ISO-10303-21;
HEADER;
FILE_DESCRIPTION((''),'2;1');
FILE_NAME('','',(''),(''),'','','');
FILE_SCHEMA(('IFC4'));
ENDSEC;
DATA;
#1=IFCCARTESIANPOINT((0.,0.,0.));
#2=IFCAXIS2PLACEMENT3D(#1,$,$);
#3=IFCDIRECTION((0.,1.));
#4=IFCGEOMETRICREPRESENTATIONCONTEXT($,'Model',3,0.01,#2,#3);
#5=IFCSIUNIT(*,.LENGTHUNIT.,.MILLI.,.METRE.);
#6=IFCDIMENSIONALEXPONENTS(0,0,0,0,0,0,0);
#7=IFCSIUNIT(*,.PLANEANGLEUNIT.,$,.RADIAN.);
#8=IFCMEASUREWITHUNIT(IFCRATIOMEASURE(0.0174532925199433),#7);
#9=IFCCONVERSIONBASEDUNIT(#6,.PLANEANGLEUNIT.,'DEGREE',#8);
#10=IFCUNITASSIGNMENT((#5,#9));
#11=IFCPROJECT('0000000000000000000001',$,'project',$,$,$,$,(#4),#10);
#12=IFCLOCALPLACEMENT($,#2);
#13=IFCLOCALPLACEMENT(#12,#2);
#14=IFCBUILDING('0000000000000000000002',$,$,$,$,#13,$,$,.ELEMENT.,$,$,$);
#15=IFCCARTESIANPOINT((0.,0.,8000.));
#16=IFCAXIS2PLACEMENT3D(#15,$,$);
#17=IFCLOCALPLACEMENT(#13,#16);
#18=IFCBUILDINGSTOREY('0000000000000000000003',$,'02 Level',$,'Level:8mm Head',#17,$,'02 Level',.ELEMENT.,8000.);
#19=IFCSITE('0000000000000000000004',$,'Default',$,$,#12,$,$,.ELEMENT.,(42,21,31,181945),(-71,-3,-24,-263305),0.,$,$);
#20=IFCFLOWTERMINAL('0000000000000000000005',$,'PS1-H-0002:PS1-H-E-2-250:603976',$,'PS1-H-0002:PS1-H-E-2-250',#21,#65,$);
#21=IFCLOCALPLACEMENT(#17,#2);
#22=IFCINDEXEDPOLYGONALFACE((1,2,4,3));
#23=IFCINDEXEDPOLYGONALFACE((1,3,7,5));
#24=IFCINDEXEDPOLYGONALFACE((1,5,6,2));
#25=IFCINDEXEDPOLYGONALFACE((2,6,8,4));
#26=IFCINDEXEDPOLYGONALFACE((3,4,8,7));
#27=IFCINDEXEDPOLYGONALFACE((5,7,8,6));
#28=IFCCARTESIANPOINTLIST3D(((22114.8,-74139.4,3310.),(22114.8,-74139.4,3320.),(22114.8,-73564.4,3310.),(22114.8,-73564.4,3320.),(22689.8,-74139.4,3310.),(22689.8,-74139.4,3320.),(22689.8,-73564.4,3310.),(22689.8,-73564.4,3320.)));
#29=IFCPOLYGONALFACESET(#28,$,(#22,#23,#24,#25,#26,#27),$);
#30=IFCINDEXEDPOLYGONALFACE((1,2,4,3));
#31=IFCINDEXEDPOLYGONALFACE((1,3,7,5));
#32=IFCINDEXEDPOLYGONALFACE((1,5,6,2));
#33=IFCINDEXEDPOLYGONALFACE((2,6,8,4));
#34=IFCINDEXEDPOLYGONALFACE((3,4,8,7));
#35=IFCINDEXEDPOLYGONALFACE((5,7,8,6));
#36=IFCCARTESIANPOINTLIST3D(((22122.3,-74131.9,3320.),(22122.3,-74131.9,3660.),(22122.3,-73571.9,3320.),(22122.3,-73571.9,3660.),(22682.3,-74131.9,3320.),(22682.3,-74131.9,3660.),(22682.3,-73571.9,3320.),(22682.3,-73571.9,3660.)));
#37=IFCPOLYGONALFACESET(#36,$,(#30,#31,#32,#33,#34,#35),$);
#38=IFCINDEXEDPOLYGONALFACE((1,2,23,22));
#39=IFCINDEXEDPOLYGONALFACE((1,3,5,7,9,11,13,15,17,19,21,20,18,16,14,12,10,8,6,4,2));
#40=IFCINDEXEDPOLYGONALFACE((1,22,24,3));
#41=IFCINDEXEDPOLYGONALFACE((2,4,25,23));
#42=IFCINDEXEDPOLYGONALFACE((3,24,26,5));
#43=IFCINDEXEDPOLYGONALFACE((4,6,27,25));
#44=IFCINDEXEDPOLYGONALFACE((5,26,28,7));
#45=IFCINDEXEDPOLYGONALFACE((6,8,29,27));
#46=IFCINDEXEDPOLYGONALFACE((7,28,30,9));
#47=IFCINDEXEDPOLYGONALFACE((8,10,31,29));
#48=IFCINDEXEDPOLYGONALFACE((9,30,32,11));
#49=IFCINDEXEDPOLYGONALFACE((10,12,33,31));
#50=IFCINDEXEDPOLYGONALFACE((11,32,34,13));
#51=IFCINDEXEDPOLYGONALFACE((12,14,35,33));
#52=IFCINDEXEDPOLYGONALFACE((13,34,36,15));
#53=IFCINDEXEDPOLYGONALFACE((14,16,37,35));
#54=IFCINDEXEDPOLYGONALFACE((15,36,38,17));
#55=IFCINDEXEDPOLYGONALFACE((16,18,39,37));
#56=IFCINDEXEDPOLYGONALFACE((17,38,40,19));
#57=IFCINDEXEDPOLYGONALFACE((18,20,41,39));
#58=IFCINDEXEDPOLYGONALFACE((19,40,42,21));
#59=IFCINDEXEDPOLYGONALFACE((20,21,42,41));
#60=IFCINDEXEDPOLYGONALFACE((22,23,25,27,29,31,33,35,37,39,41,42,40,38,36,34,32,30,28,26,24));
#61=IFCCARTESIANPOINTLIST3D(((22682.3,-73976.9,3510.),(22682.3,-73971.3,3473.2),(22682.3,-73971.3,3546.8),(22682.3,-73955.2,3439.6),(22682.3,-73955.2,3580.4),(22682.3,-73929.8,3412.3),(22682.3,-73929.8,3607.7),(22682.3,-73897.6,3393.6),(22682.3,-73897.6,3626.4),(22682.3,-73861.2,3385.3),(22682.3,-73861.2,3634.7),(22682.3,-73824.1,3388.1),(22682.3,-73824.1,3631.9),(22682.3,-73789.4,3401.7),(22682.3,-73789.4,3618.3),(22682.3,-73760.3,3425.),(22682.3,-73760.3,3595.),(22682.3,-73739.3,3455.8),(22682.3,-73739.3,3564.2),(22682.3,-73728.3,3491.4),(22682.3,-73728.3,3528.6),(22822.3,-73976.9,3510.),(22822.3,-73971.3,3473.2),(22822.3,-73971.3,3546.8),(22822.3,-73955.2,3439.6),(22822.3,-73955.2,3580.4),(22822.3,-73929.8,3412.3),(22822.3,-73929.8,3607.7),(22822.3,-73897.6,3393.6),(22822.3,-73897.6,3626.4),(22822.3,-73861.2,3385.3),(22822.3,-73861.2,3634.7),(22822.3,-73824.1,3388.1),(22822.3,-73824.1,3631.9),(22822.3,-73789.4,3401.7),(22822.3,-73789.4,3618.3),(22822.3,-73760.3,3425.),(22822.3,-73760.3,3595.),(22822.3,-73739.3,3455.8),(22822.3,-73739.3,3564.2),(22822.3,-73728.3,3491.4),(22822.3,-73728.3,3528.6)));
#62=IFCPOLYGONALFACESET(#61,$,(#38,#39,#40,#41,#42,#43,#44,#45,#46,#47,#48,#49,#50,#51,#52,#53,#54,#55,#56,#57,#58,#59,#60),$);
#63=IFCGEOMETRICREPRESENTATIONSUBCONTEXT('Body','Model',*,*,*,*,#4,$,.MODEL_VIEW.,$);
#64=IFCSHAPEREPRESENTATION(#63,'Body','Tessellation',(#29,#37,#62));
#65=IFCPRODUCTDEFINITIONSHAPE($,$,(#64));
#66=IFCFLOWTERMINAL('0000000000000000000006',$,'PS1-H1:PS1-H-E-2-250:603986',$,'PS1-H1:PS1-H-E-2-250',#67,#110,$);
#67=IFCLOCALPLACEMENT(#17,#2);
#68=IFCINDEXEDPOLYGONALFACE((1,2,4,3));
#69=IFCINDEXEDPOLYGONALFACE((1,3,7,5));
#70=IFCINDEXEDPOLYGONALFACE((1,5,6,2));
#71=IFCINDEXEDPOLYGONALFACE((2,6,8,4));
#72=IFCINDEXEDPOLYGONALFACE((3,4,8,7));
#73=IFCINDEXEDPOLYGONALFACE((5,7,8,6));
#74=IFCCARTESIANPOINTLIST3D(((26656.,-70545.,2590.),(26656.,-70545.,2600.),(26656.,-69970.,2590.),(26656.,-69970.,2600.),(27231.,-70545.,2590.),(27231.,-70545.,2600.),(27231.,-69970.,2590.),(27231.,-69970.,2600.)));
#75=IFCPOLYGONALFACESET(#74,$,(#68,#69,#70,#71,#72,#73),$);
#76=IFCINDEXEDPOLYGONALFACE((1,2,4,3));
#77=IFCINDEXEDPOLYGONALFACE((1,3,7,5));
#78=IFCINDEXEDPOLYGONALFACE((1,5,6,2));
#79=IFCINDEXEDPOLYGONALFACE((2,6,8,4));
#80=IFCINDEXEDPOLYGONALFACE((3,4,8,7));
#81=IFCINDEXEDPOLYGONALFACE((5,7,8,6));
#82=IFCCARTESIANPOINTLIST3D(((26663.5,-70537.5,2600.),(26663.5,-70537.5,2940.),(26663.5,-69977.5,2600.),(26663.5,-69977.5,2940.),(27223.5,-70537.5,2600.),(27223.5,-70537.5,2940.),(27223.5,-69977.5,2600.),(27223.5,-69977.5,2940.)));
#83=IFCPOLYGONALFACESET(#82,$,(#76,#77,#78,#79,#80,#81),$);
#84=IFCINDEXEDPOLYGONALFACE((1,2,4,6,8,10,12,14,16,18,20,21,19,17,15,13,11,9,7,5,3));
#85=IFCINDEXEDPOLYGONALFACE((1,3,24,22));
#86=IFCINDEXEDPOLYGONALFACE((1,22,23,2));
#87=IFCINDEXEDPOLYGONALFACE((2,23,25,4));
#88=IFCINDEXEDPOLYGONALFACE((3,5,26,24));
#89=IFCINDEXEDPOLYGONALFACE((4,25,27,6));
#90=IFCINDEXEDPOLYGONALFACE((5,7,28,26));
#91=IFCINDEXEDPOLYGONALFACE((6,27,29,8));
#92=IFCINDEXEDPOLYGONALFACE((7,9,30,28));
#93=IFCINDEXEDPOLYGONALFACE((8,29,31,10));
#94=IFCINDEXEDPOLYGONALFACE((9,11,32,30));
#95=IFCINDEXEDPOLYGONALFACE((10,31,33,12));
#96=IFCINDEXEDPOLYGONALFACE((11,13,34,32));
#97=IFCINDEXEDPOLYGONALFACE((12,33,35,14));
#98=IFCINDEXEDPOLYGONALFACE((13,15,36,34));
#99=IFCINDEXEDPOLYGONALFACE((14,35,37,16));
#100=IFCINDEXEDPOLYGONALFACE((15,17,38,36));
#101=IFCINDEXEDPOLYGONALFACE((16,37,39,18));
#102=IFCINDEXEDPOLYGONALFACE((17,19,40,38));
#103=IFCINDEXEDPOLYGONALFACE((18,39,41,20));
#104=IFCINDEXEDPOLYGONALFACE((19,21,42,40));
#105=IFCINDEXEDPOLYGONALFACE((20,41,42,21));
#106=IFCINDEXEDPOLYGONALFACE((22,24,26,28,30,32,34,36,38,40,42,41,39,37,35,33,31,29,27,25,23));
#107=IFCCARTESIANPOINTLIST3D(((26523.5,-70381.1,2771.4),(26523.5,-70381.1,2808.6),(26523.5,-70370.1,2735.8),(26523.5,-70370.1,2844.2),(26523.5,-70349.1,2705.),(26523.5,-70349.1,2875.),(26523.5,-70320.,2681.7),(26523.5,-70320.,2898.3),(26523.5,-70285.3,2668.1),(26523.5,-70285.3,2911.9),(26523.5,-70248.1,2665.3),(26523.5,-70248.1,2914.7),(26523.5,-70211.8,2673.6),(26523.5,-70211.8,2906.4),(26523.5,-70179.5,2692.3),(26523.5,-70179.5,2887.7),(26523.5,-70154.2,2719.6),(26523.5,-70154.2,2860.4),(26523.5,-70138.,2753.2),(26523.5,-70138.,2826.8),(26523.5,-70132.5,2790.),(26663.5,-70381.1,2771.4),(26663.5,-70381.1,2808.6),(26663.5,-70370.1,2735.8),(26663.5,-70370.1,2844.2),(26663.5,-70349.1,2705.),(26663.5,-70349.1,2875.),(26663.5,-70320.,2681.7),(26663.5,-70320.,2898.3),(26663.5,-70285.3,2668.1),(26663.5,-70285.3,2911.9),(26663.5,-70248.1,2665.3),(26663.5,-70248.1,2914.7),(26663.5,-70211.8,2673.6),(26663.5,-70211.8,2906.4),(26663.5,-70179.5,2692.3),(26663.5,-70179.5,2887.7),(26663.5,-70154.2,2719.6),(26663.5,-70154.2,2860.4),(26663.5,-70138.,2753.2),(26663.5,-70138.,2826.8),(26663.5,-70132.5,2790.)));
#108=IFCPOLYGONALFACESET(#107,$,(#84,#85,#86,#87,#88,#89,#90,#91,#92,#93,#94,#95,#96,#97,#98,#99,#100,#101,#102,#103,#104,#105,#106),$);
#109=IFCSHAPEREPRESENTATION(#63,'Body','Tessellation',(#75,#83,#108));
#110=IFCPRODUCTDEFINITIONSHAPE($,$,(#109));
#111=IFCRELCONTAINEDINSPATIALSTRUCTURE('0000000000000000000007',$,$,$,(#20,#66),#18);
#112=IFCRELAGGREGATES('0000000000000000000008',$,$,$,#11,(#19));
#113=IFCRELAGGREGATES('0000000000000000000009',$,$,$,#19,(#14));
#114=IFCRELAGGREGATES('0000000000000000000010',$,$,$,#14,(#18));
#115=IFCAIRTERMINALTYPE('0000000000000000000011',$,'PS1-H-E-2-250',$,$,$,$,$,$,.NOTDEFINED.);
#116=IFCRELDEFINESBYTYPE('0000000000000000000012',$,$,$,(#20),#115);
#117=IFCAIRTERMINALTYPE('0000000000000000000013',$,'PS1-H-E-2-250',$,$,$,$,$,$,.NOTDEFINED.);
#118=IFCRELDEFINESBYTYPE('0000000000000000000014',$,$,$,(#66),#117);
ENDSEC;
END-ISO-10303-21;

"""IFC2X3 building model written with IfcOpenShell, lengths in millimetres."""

from ifc_helpers import new_model, entity, si_unit, converted_unit, direction, frame, frame_2d, origin, origin_2d_with_axis, place, context, subcontext, project, spatial, rectangle, circle, extrude, source, transform, mapped, type_object, type_shapes, element, save


model = new_model("IFC2X3")

# Units and contexts
model_context = context("Model", 3, precision=0.01, world=origin(), true_north=direction((0.0, 1.0)))
body_context = subcontext(model_context, "Body", "Model", "MODEL_VIEW")
ifc_project = project(units=[si_unit("LENGTHUNIT", "METRE", prefix="MILLI"), converted_unit("PLANEANGLEUNIT", "DEGREE", entity("IfcRatioMeasure", 0.0174532925199433), si_unit("PLANEANGLEUNIT", "RADIAN"), dimensions=[0, 0, 0, 0, 0, 0, 0])], contexts=[model_context])

# Site, building, storey
site_placement = place(None, origin())
site = spatial("IfcSite", under=ifc_project, at=site_placement, Name="Default", CompositionType="ELEMENT", RefLatitude=(42, 21, 31, 181945), RefLongitude=(-71, -3, -24, -263305), RefElevation=0.0)
building_placement = place(site_placement, origin())
building = spatial("IfcBuilding", under=site, at=building_placement, CompositionType="ELEMENT")
storey_placement = place(building_placement, frame((0.0, 0.0, 8000.0)))
storey = spatial("IfcBuildingStorey", under=building, at=storey_placement, Name="02 Level", ObjectType="Level:8mm Head", LongName="02 Level", CompositionType="ELEMENT", Elevation=8000.0)

# Flow terminals
air_terminal_type_1 = type_object("IfcAirTerminalType", Name="PS1-H-E-2-250", PredefinedType="NOTDEFINED")
shared_shape_1 = source(origin(), body_context, "Body", "SweptSolid", [
    extrude(rectangle(XDim=575.0, YDim=575.0, at=origin_2d_with_axis()), frame((0.0, 0.0, -10.0), z_axis=(0.0, 0.0, 1.0), x_axis=(-1.0, 0.0, 0.0)), (0.0, 0.0, 1.0), 10.0),
    extrude(rectangle(XDim=560.0, YDim=560.0, at=origin_2d_with_axis()), frame((0.0, 0.0, 0.0), z_axis=(0.0, 0.0, 1.0), x_axis=(-1.0, 0.0, 0.0)), (0.0, 0.0, 1.0), 340.0),
    extrude(circle(Radius=125.0, at=frame_2d((0.0, 0.0), x_axis=(1.0, 0.0))), frame((-420.0, 0.0, 190.0), z_axis=(1.0, 0.0, 0.0), x_axis=(0.0, 1.0, 0.0)), (0.0, 0.0, 1.0), 140.0),
])
type_shapes(air_terminal_type_1, [shared_shape_1])
flow_terminal_1_placement = place(storey_placement, frame((22402.3, -73851.9, 3320.0), z_axis=(0.0, 0.0, 1.0), x_axis=(-1.0, 0.0, 0.0)))
element("IfcFlowTerminal", 1, at=flow_terminal_1_placement, inside=storey, type_object=air_terminal_type_1, Name="PS1-H-0002:PS1-H-E-2-250:603976", ObjectType="PS1-H-0002:PS1-H-E-2-250", context=body_context, shape_type="MappedRepresentation", body=[
    mapped(shared_shape_1, transform((0.0, 0.0, 0.0), scale=1.0)),
])
air_terminal_type_2 = type_object("IfcAirTerminalType", Name="PS1-H-E-2-250", PredefinedType="NOTDEFINED")
shared_shape_2 = source(origin(), body_context, "Body", "SweptSolid", [
    extrude(rectangle(XDim=575.0, YDim=575.0, at=origin_2d_with_axis()), frame((0.0, 0.0, -10.0), z_axis=(0.0, 0.0, 1.0), x_axis=(-1.0, 0.0, 0.0)), (0.0, 0.0, 1.0), 10.0),
    extrude(rectangle(XDim=560.0, YDim=560.0, at=origin_2d_with_axis()), frame((0.0, 0.0, 0.0), z_axis=(0.0, 0.0, 1.0), x_axis=(-1.0, 0.0, 0.0)), (0.0, 0.0, 1.0), 340.0),
    extrude(circle(Radius=125.0, at=frame_2d((0.0, 0.0), x_axis=(1.0, 0.0))), frame((-420.0, 0.0, 190.0), z_axis=(1.0, 0.0, 0.0), x_axis=(0.0, 1.0, 0.0)), (0.0, 0.0, 1.0), 140.0),
])
type_shapes(air_terminal_type_2, [shared_shape_2])
flow_terminal_2_placement = place(storey_placement, frame((26943.5, -70257.5, 2600.0)))
element("IfcFlowTerminal", 2, at=flow_terminal_2_placement, inside=storey, type_object=air_terminal_type_2, Name="PS1-H1:PS1-H-E-2-250:603986", ObjectType="PS1-H1:PS1-H-E-2-250", context=body_context, shape_type="MappedRepresentation", body=[
    mapped(shared_shape_2, transform((0.0, 0.0, 0.0), scale=1.0)),
])

save(model, "model.ifc")
